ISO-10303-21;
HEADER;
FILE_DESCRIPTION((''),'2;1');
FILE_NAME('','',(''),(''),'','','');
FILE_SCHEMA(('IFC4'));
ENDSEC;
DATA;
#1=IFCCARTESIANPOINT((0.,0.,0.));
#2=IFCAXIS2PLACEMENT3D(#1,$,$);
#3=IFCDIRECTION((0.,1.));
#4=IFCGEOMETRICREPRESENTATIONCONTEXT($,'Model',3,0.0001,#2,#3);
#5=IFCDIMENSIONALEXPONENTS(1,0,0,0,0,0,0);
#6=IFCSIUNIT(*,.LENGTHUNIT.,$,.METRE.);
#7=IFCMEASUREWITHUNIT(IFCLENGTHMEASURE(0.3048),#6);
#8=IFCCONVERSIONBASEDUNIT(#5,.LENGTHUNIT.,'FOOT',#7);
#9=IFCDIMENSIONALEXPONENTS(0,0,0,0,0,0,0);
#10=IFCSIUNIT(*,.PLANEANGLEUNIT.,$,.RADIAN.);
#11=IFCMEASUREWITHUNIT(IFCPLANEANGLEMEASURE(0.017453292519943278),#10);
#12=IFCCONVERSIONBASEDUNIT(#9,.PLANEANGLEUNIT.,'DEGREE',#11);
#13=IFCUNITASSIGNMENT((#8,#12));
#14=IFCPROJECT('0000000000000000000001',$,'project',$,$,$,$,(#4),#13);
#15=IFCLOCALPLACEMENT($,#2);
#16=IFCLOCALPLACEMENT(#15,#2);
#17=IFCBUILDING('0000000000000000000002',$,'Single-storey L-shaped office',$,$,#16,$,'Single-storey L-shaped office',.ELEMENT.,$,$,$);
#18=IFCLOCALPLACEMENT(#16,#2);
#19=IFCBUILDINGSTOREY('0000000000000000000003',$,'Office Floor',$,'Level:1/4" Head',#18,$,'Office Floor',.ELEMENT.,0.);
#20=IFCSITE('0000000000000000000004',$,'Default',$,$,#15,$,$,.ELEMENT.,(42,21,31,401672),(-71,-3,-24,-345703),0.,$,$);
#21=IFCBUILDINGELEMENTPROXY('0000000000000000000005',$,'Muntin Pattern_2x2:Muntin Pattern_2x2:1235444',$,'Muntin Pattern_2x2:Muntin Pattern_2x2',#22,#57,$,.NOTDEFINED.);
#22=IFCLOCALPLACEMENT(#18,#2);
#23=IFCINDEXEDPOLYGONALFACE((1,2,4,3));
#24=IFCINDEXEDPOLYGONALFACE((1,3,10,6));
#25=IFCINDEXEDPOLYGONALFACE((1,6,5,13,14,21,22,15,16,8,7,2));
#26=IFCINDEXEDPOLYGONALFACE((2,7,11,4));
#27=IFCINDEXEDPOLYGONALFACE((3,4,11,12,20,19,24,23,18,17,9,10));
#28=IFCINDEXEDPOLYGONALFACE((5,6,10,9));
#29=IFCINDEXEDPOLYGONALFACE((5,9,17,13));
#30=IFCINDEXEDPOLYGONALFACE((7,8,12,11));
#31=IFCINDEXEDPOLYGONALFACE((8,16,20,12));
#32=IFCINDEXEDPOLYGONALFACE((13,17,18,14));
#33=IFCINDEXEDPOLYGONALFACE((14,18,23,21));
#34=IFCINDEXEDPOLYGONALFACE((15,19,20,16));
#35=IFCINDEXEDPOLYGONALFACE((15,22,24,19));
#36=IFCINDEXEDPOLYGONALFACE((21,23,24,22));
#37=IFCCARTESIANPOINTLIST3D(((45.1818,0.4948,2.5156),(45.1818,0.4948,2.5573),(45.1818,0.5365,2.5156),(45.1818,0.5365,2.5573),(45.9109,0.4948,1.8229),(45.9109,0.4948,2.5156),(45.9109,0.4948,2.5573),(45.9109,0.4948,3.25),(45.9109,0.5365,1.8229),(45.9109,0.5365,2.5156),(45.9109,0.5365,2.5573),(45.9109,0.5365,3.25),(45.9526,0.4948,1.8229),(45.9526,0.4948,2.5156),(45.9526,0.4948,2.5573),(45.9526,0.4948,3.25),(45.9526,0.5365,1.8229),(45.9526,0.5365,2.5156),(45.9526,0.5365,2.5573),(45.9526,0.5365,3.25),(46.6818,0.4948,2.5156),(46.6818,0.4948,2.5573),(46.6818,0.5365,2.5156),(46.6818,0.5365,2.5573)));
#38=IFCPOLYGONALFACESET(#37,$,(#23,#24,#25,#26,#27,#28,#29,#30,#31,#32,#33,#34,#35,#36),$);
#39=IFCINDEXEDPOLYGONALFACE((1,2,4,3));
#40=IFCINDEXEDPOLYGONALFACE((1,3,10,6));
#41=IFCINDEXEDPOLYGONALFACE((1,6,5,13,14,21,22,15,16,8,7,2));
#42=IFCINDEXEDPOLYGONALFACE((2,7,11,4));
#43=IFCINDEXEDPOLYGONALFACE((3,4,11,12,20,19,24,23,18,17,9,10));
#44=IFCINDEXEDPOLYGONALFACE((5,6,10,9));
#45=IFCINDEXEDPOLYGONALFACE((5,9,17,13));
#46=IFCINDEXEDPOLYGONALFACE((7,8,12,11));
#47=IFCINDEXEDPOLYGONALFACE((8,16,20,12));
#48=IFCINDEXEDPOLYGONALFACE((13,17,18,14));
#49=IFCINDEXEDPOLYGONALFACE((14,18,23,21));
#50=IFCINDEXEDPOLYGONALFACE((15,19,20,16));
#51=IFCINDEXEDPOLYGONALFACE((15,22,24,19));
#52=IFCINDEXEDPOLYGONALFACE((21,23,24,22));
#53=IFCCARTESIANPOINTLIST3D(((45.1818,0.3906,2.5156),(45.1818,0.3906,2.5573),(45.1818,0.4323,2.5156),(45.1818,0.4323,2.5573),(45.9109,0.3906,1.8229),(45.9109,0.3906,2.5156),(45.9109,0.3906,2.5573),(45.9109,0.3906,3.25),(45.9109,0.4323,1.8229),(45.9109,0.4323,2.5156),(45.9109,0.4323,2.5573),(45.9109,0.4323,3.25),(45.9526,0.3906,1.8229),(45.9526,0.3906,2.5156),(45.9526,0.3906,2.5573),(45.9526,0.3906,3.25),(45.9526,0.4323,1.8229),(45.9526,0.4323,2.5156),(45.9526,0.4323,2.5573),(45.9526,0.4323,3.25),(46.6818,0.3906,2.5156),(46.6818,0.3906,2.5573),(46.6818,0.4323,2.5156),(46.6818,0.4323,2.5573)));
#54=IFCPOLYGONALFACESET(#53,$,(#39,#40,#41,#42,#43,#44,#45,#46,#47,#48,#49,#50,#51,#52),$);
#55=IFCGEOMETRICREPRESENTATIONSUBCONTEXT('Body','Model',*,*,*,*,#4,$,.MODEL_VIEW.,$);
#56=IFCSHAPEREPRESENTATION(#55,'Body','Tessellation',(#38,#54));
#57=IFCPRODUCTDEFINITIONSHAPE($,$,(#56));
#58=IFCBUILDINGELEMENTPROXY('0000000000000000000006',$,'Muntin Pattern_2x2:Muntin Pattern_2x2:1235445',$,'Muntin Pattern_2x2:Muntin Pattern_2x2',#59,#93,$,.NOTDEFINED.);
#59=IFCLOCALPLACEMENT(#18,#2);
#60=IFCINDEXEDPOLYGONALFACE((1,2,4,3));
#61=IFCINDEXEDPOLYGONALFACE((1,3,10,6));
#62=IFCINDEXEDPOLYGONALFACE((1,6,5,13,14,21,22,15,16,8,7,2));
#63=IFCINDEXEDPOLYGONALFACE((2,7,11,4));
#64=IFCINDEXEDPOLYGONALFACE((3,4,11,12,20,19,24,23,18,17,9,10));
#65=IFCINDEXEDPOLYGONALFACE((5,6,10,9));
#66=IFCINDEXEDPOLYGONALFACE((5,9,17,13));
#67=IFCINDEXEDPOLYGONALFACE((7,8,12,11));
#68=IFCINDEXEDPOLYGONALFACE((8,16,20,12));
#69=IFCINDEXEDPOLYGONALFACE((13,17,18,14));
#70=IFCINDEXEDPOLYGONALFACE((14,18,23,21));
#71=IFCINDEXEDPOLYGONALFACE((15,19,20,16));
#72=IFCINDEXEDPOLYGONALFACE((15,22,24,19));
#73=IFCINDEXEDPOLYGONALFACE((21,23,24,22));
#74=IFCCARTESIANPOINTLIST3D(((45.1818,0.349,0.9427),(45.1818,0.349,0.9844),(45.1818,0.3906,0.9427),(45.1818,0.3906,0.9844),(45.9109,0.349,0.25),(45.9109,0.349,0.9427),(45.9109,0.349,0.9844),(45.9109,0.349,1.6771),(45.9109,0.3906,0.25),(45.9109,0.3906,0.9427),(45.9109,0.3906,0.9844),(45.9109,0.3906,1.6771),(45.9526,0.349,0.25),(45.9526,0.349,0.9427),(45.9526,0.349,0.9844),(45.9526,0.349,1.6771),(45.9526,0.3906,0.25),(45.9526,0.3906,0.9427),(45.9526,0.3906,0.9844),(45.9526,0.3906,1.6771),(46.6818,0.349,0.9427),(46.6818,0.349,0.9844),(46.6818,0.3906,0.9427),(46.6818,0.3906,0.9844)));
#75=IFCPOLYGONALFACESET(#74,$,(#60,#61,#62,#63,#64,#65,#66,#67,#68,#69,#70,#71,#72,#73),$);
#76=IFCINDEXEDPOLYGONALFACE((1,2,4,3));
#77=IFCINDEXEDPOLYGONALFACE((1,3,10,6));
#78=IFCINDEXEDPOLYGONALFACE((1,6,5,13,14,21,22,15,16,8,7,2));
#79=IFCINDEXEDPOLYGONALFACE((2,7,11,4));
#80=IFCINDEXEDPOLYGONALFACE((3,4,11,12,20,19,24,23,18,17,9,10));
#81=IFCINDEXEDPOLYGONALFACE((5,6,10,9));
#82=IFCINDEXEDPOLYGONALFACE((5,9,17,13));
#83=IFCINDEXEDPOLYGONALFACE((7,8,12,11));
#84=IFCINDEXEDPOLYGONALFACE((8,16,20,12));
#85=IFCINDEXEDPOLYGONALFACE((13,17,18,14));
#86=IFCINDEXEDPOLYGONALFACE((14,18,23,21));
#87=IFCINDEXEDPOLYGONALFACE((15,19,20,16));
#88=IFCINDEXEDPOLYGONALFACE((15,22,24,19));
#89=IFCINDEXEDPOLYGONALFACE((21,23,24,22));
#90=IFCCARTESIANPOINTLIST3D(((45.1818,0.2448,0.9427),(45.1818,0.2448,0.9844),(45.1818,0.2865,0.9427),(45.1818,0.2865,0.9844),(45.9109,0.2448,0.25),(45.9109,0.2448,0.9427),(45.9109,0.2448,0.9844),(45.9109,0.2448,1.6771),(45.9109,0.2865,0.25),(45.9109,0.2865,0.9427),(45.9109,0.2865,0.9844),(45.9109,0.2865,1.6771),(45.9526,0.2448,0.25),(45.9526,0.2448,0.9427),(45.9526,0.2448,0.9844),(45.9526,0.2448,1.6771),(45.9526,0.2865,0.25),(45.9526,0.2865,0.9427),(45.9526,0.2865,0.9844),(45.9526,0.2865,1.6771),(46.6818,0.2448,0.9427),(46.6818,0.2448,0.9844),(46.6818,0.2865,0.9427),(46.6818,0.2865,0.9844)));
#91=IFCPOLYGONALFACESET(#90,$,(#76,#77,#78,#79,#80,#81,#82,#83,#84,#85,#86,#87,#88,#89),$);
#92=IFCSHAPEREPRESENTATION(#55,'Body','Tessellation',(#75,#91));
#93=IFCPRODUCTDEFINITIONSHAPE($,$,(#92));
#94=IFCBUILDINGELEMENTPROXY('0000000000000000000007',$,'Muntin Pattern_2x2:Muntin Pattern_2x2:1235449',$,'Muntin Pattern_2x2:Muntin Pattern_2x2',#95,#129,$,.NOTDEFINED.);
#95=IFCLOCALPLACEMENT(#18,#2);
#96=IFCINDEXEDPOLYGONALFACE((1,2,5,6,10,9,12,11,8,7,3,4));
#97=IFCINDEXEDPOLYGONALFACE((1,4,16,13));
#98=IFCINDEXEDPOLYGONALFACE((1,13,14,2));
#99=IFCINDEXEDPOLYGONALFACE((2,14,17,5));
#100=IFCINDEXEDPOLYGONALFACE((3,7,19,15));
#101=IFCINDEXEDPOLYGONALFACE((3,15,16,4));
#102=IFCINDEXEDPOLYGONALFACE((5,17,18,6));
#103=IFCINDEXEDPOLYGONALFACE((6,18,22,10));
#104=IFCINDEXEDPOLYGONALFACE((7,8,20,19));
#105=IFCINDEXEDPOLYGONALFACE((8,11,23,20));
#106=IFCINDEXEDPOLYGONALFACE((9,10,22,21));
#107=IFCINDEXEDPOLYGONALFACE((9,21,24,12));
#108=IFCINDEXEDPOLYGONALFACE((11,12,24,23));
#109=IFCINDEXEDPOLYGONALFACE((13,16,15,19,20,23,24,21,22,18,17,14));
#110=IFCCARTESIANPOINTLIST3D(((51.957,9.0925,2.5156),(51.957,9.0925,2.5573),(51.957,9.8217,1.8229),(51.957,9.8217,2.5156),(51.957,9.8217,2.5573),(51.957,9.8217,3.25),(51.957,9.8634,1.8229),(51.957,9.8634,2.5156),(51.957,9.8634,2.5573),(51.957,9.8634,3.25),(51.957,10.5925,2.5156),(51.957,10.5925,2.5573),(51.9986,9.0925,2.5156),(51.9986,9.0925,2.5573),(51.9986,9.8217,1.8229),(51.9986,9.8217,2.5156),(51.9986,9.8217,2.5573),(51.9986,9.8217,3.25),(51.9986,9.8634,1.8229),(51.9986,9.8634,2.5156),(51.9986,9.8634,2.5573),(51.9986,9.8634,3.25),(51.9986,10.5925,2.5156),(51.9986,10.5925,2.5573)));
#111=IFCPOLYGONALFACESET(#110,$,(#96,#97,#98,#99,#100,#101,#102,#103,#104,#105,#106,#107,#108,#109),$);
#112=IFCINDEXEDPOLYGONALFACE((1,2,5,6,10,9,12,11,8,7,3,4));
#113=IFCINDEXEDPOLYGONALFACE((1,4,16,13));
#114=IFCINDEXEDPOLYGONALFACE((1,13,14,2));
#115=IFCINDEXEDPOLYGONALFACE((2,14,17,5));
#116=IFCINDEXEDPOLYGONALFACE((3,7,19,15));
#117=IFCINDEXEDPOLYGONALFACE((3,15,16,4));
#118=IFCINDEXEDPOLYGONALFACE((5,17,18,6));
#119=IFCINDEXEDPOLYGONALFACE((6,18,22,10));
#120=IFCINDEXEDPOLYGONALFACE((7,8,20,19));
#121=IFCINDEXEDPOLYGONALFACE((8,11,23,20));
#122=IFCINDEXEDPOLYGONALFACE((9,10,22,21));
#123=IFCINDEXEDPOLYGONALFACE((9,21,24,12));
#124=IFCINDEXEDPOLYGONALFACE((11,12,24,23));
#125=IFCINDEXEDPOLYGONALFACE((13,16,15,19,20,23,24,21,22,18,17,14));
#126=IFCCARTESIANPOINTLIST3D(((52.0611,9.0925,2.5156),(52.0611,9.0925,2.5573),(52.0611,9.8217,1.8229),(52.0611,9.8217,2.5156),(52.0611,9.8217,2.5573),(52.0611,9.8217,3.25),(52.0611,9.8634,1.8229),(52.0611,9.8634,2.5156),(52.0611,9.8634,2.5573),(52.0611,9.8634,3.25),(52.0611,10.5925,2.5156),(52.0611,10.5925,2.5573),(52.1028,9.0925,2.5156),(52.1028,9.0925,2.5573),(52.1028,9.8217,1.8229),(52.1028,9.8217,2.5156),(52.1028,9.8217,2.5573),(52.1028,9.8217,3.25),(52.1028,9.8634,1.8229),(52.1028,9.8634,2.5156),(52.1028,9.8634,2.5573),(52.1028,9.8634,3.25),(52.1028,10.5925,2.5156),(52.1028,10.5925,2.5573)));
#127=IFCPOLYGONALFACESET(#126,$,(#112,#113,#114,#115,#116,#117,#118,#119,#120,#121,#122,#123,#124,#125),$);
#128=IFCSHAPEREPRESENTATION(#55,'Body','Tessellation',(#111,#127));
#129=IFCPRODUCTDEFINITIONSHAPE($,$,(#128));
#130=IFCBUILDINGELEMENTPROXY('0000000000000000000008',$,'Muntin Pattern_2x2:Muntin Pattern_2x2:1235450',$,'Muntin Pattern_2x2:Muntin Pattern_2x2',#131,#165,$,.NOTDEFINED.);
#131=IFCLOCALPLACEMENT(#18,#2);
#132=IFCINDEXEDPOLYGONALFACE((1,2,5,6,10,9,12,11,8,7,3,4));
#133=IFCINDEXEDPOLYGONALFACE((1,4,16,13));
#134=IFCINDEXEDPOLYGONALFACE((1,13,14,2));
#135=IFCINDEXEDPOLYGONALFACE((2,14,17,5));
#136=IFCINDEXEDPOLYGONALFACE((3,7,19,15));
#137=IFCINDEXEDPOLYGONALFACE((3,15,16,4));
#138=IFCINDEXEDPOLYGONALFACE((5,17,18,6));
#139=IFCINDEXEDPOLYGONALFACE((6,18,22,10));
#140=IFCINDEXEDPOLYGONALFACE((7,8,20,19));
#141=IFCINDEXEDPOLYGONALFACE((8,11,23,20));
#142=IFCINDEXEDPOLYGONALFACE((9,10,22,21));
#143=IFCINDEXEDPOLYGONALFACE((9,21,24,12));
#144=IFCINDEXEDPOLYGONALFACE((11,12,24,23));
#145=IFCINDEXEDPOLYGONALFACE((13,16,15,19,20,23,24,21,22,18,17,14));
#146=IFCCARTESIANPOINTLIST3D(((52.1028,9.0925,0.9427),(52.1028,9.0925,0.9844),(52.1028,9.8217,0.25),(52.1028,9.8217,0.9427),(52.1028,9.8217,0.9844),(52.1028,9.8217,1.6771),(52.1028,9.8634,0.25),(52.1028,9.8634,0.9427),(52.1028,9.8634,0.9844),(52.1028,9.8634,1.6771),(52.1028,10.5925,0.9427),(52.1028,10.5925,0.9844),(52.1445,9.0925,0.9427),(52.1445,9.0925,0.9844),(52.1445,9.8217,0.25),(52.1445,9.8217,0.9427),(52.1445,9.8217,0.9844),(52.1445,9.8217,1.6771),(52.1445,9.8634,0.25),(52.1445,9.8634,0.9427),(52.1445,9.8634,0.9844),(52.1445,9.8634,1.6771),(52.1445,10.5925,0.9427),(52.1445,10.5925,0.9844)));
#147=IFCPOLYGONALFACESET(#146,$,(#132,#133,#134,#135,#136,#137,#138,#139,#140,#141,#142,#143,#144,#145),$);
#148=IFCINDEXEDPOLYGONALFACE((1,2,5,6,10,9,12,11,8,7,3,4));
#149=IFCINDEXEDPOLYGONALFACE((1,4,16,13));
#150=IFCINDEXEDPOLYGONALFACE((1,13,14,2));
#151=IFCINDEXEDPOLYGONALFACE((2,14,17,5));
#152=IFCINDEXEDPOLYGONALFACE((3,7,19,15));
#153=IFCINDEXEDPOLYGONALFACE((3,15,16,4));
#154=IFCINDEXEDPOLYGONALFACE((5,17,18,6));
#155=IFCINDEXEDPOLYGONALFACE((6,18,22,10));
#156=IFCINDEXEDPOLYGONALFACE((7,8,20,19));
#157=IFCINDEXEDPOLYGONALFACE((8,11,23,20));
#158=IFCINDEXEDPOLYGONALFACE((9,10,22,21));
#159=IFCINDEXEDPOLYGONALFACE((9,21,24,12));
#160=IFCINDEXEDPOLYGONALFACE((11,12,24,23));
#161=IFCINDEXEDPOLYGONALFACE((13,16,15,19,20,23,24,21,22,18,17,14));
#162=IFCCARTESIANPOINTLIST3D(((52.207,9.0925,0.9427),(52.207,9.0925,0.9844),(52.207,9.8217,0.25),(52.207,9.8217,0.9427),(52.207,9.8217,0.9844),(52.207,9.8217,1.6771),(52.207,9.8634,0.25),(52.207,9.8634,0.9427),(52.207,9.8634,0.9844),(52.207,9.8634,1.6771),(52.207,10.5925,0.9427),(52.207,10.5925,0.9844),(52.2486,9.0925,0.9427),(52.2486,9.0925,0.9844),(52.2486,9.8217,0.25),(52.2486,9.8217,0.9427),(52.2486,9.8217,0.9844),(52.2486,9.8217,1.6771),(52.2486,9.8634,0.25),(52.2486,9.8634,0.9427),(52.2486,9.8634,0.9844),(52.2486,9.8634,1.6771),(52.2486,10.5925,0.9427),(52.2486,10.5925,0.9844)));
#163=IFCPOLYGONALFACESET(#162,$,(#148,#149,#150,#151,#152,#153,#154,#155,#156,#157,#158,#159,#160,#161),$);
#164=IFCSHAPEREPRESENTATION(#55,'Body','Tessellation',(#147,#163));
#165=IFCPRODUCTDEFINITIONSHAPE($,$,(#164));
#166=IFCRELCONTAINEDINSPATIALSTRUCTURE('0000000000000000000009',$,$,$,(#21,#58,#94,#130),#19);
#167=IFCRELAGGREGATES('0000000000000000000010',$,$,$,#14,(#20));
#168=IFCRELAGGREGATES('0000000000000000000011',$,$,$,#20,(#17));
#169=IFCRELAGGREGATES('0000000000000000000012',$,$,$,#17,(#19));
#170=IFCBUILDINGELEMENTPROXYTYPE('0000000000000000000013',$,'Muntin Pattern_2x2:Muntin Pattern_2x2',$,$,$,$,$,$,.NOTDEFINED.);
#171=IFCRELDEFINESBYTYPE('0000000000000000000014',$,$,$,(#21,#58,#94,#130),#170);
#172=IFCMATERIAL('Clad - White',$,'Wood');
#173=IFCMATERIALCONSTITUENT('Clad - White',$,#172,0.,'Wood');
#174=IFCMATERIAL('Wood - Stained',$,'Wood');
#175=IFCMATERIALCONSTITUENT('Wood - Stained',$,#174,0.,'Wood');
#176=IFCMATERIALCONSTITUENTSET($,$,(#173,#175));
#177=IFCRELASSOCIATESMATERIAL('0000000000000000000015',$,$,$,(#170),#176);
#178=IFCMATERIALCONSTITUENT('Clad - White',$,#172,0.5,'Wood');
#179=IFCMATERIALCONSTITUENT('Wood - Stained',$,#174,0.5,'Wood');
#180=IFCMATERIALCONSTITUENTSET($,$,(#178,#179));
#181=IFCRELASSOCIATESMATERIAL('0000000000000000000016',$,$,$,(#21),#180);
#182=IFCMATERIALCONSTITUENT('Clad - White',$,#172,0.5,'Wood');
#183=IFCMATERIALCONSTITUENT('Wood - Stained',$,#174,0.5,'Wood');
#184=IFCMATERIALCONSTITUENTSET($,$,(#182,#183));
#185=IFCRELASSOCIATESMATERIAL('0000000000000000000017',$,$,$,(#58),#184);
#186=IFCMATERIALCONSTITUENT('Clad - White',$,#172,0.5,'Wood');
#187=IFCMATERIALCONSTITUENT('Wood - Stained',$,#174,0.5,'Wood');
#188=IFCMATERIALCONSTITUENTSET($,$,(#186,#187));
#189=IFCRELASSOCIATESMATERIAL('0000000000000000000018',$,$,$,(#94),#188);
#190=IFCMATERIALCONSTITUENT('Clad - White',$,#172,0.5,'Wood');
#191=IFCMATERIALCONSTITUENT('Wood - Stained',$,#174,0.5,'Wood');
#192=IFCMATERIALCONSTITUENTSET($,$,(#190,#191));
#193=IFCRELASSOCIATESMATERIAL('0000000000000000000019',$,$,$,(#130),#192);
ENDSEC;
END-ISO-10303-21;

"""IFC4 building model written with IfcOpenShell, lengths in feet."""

from ifc_helpers import new_model, entity, si_unit, converted_unit, direction, frame, origin, place, context, subcontext, project, spatial, indexed_curve, outline, extrude, source, transform, mapped, material, constituent, constituent_set, type_object, type_shapes, element, save


model = new_model("IFC4")

# Units and contexts
model_context = context("Model", 3, precision=0.0001, world=origin(), true_north=direction((0.0, 1.0)))
body_context = subcontext(model_context, "Body", "Model", "MODEL_VIEW")
ifc_project = project(units=[converted_unit("LENGTHUNIT", "FOOT", entity("IfcLengthMeasure", 0.3048), si_unit("LENGTHUNIT", "METRE"), dimensions=[1, 0, 0, 0, 0, 0, 0]), converted_unit("PLANEANGLEUNIT", "DEGREE", entity("IfcPlaneAngleMeasure", 0.017453292519943278), si_unit("PLANEANGLEUNIT", "RADIAN"), dimensions=[0, 0, 0, 0, 0, 0, 0])], contexts=[model_context])

# Site, building, storey
site_placement = place(None, origin())
site = spatial("IfcSite", under=ifc_project, at=site_placement, Name="Default", CompositionType="ELEMENT", RefLatitude=(42, 21, 31, 401672), RefLongitude=(-71, -3, -24, -345703), RefElevation=0.0)
building_placement = place(site_placement, origin())
building = spatial("IfcBuilding", under=site, at=building_placement, Name="Single-storey L-shaped office", LongName="Single-storey L-shaped office", CompositionType="ELEMENT")
storey_placement = place(building_placement, origin())
storey = spatial("IfcBuildingStorey", under=building, at=storey_placement, Name="Office Floor", ObjectType="Level:1/4\" Head", LongName="Office Floor", CompositionType="ELEMENT", Elevation=0.0)

# Shared definitions
ifc_material_1 = material(Name="Wood - Stained", Category="Wood")

# Building element proxies
ifc_material_2 = material(Name="Clad - White", Category="Wood")
ifc_constituent_1 = constituent(ifc_material_2, Name="Clad - White", Category="Wood", fraction=0.5)
ifc_constituent_2 = constituent(ifc_material_1, Name="Wood - Stained", Category="Wood", fraction=0.5)
ifc_constituent_set_1 = constituent_set(constituents=[ifc_constituent_1, ifc_constituent_2])
ifc_constituent_3 = constituent(ifc_material_2, Name="Clad - White", Category="Wood", fraction=0.0)
ifc_constituent_4 = constituent(ifc_material_1, Name="Wood - Stained", Category="Wood", fraction=0.0)
ifc_constituent_set_2 = constituent_set(constituents=[ifc_constituent_3, ifc_constituent_4])
building_element_proxy_type_1 = type_object("IfcBuildingElementProxyType", Name="Muntin Pattern_2x2:Muntin Pattern_2x2", PredefinedType="NOTDEFINED", material=ifc_constituent_set_2)
shared_shape_1 = source(origin(), body_context, "Body", "SweptSolid", [
    extrude(outline(indexed_curve([(0.0208, -0.0208), (0.7135, -0.0208), (0.7135, 0.0208), (0.0208, 0.0208), (0.0208, 0.75), (-0.0208, 0.75), (-0.0208, 0.0208), (-0.7135, 0.0208), (-0.7135, -0.0208), (-0.0208, -0.0208), (-0.0208, -0.75), (0.0208, -0.75), (0.0208, -0.0208)], self_intersect=False)), frame((0.0, 0.0312, 0.7135), z_axis=(0.0, 1.0, 0.0), x_axis=(0.0, 0.0, 1.0)), (0.0, 0.0, 1.0), 0.0417),
    extrude(outline(indexed_curve([(0.0208, -0.0208), (0.7135, -0.0208), (0.7135, 0.0208), (0.0208, 0.0208), (0.0208, 0.75), (-0.0208, 0.75), (-0.0208, 0.0208), (-0.7135, 0.0208), (-0.7135, -0.0208), (-0.0208, -0.0208), (-0.0208, -0.75), (0.0208, -0.75), (0.0208, -0.0208)], self_intersect=False)), frame((0.0, -0.0729, 0.7135), z_axis=(0.0, 1.0, 0.0), x_axis=(0.0, 0.0, 1.0)), (0.0, 0.0, 1.0), 0.0417),
])
type_shapes(building_element_proxy_type_1, [shared_shape_1])
proxy_1_placement = place(storey_placement, frame((45.9318, 0.4635, 1.8229)))
element("IfcBuildingElementProxy", 1, at=proxy_1_placement, inside=storey, type_object=building_element_proxy_type_1, material=ifc_constituent_set_1, Name="Muntin Pattern_2x2:Muntin Pattern_2x2:1235444", ObjectType="Muntin Pattern_2x2:Muntin Pattern_2x2", PredefinedType="NOTDEFINED", context=body_context, shape_type="MappedRepresentation", body=[
    mapped(shared_shape_1, transform((0.0, 0.0, 0.0), scale=1.0)),
])
ifc_constituent_5 = constituent(ifc_material_2, Name="Clad - White", Category="Wood", fraction=0.5)
ifc_constituent_6 = constituent(ifc_material_1, Name="Wood - Stained", Category="Wood", fraction=0.5)
ifc_constituent_set_3 = constituent_set(constituents=[ifc_constituent_5, ifc_constituent_6])
proxy_2_placement = place(storey_placement, frame((45.9318, 0.3177, 0.25)))
element("IfcBuildingElementProxy", 2, at=proxy_2_placement, inside=storey, type_object=building_element_proxy_type_1, material=ifc_constituent_set_3, Name="Muntin Pattern_2x2:Muntin Pattern_2x2:1235445", ObjectType="Muntin Pattern_2x2:Muntin Pattern_2x2", PredefinedType="NOTDEFINED", context=body_context, shape_type="MappedRepresentation", body=[
    mapped(shared_shape_1, transform((0.0, 0.0, 0.0), scale=1.0)),
])
ifc_constituent_7 = constituent(ifc_material_2, Name="Clad - White", Category="Wood", fraction=0.5)
ifc_constituent_8 = constituent(ifc_material_1, Name="Wood - Stained", Category="Wood", fraction=0.5)
ifc_constituent_set_4 = constituent_set(constituents=[ifc_constituent_7, ifc_constituent_8])
proxy_3_placement = place(storey_placement, frame((52.0299, 9.8425, 1.8229), z_axis=(0.0, 0.0, 1.0), x_axis=(0.0, 1.0, 0.0)))
element("IfcBuildingElementProxy", 3, at=proxy_3_placement, inside=storey, type_object=building_element_proxy_type_1, material=ifc_constituent_set_4, Name="Muntin Pattern_2x2:Muntin Pattern_2x2:1235449", ObjectType="Muntin Pattern_2x2:Muntin Pattern_2x2", PredefinedType="NOTDEFINED", context=body_context, shape_type="MappedRepresentation", body=[
    mapped(shared_shape_1, transform((0.0, 0.0, 0.0), scale=1.0)),
])
ifc_constituent_9 = constituent(ifc_material_2, Name="Clad - White", Category="Wood", fraction=0.5)
ifc_constituent_10 = constituent(ifc_material_1, Name="Wood - Stained", Category="Wood", fraction=0.5)
ifc_constituent_set_5 = constituent_set(constituents=[ifc_constituent_9, ifc_constituent_10])
proxy_4_placement = place(storey_placement, frame((52.1757, 9.8425, 0.25), z_axis=(0.0, 0.0, 1.0), x_axis=(0.0, 1.0, 0.0)))
element("IfcBuildingElementProxy", 4, at=proxy_4_placement, inside=storey, type_object=building_element_proxy_type_1, material=ifc_constituent_set_5, Name="Muntin Pattern_2x2:Muntin Pattern_2x2:1235450", ObjectType="Muntin Pattern_2x2:Muntin Pattern_2x2", PredefinedType="NOTDEFINED", context=body_context, shape_type="MappedRepresentation", body=[
    mapped(shared_shape_1, transform((0.0, 0.0, 0.0), scale=1.0)),
])

save(model, "model.ifc")
